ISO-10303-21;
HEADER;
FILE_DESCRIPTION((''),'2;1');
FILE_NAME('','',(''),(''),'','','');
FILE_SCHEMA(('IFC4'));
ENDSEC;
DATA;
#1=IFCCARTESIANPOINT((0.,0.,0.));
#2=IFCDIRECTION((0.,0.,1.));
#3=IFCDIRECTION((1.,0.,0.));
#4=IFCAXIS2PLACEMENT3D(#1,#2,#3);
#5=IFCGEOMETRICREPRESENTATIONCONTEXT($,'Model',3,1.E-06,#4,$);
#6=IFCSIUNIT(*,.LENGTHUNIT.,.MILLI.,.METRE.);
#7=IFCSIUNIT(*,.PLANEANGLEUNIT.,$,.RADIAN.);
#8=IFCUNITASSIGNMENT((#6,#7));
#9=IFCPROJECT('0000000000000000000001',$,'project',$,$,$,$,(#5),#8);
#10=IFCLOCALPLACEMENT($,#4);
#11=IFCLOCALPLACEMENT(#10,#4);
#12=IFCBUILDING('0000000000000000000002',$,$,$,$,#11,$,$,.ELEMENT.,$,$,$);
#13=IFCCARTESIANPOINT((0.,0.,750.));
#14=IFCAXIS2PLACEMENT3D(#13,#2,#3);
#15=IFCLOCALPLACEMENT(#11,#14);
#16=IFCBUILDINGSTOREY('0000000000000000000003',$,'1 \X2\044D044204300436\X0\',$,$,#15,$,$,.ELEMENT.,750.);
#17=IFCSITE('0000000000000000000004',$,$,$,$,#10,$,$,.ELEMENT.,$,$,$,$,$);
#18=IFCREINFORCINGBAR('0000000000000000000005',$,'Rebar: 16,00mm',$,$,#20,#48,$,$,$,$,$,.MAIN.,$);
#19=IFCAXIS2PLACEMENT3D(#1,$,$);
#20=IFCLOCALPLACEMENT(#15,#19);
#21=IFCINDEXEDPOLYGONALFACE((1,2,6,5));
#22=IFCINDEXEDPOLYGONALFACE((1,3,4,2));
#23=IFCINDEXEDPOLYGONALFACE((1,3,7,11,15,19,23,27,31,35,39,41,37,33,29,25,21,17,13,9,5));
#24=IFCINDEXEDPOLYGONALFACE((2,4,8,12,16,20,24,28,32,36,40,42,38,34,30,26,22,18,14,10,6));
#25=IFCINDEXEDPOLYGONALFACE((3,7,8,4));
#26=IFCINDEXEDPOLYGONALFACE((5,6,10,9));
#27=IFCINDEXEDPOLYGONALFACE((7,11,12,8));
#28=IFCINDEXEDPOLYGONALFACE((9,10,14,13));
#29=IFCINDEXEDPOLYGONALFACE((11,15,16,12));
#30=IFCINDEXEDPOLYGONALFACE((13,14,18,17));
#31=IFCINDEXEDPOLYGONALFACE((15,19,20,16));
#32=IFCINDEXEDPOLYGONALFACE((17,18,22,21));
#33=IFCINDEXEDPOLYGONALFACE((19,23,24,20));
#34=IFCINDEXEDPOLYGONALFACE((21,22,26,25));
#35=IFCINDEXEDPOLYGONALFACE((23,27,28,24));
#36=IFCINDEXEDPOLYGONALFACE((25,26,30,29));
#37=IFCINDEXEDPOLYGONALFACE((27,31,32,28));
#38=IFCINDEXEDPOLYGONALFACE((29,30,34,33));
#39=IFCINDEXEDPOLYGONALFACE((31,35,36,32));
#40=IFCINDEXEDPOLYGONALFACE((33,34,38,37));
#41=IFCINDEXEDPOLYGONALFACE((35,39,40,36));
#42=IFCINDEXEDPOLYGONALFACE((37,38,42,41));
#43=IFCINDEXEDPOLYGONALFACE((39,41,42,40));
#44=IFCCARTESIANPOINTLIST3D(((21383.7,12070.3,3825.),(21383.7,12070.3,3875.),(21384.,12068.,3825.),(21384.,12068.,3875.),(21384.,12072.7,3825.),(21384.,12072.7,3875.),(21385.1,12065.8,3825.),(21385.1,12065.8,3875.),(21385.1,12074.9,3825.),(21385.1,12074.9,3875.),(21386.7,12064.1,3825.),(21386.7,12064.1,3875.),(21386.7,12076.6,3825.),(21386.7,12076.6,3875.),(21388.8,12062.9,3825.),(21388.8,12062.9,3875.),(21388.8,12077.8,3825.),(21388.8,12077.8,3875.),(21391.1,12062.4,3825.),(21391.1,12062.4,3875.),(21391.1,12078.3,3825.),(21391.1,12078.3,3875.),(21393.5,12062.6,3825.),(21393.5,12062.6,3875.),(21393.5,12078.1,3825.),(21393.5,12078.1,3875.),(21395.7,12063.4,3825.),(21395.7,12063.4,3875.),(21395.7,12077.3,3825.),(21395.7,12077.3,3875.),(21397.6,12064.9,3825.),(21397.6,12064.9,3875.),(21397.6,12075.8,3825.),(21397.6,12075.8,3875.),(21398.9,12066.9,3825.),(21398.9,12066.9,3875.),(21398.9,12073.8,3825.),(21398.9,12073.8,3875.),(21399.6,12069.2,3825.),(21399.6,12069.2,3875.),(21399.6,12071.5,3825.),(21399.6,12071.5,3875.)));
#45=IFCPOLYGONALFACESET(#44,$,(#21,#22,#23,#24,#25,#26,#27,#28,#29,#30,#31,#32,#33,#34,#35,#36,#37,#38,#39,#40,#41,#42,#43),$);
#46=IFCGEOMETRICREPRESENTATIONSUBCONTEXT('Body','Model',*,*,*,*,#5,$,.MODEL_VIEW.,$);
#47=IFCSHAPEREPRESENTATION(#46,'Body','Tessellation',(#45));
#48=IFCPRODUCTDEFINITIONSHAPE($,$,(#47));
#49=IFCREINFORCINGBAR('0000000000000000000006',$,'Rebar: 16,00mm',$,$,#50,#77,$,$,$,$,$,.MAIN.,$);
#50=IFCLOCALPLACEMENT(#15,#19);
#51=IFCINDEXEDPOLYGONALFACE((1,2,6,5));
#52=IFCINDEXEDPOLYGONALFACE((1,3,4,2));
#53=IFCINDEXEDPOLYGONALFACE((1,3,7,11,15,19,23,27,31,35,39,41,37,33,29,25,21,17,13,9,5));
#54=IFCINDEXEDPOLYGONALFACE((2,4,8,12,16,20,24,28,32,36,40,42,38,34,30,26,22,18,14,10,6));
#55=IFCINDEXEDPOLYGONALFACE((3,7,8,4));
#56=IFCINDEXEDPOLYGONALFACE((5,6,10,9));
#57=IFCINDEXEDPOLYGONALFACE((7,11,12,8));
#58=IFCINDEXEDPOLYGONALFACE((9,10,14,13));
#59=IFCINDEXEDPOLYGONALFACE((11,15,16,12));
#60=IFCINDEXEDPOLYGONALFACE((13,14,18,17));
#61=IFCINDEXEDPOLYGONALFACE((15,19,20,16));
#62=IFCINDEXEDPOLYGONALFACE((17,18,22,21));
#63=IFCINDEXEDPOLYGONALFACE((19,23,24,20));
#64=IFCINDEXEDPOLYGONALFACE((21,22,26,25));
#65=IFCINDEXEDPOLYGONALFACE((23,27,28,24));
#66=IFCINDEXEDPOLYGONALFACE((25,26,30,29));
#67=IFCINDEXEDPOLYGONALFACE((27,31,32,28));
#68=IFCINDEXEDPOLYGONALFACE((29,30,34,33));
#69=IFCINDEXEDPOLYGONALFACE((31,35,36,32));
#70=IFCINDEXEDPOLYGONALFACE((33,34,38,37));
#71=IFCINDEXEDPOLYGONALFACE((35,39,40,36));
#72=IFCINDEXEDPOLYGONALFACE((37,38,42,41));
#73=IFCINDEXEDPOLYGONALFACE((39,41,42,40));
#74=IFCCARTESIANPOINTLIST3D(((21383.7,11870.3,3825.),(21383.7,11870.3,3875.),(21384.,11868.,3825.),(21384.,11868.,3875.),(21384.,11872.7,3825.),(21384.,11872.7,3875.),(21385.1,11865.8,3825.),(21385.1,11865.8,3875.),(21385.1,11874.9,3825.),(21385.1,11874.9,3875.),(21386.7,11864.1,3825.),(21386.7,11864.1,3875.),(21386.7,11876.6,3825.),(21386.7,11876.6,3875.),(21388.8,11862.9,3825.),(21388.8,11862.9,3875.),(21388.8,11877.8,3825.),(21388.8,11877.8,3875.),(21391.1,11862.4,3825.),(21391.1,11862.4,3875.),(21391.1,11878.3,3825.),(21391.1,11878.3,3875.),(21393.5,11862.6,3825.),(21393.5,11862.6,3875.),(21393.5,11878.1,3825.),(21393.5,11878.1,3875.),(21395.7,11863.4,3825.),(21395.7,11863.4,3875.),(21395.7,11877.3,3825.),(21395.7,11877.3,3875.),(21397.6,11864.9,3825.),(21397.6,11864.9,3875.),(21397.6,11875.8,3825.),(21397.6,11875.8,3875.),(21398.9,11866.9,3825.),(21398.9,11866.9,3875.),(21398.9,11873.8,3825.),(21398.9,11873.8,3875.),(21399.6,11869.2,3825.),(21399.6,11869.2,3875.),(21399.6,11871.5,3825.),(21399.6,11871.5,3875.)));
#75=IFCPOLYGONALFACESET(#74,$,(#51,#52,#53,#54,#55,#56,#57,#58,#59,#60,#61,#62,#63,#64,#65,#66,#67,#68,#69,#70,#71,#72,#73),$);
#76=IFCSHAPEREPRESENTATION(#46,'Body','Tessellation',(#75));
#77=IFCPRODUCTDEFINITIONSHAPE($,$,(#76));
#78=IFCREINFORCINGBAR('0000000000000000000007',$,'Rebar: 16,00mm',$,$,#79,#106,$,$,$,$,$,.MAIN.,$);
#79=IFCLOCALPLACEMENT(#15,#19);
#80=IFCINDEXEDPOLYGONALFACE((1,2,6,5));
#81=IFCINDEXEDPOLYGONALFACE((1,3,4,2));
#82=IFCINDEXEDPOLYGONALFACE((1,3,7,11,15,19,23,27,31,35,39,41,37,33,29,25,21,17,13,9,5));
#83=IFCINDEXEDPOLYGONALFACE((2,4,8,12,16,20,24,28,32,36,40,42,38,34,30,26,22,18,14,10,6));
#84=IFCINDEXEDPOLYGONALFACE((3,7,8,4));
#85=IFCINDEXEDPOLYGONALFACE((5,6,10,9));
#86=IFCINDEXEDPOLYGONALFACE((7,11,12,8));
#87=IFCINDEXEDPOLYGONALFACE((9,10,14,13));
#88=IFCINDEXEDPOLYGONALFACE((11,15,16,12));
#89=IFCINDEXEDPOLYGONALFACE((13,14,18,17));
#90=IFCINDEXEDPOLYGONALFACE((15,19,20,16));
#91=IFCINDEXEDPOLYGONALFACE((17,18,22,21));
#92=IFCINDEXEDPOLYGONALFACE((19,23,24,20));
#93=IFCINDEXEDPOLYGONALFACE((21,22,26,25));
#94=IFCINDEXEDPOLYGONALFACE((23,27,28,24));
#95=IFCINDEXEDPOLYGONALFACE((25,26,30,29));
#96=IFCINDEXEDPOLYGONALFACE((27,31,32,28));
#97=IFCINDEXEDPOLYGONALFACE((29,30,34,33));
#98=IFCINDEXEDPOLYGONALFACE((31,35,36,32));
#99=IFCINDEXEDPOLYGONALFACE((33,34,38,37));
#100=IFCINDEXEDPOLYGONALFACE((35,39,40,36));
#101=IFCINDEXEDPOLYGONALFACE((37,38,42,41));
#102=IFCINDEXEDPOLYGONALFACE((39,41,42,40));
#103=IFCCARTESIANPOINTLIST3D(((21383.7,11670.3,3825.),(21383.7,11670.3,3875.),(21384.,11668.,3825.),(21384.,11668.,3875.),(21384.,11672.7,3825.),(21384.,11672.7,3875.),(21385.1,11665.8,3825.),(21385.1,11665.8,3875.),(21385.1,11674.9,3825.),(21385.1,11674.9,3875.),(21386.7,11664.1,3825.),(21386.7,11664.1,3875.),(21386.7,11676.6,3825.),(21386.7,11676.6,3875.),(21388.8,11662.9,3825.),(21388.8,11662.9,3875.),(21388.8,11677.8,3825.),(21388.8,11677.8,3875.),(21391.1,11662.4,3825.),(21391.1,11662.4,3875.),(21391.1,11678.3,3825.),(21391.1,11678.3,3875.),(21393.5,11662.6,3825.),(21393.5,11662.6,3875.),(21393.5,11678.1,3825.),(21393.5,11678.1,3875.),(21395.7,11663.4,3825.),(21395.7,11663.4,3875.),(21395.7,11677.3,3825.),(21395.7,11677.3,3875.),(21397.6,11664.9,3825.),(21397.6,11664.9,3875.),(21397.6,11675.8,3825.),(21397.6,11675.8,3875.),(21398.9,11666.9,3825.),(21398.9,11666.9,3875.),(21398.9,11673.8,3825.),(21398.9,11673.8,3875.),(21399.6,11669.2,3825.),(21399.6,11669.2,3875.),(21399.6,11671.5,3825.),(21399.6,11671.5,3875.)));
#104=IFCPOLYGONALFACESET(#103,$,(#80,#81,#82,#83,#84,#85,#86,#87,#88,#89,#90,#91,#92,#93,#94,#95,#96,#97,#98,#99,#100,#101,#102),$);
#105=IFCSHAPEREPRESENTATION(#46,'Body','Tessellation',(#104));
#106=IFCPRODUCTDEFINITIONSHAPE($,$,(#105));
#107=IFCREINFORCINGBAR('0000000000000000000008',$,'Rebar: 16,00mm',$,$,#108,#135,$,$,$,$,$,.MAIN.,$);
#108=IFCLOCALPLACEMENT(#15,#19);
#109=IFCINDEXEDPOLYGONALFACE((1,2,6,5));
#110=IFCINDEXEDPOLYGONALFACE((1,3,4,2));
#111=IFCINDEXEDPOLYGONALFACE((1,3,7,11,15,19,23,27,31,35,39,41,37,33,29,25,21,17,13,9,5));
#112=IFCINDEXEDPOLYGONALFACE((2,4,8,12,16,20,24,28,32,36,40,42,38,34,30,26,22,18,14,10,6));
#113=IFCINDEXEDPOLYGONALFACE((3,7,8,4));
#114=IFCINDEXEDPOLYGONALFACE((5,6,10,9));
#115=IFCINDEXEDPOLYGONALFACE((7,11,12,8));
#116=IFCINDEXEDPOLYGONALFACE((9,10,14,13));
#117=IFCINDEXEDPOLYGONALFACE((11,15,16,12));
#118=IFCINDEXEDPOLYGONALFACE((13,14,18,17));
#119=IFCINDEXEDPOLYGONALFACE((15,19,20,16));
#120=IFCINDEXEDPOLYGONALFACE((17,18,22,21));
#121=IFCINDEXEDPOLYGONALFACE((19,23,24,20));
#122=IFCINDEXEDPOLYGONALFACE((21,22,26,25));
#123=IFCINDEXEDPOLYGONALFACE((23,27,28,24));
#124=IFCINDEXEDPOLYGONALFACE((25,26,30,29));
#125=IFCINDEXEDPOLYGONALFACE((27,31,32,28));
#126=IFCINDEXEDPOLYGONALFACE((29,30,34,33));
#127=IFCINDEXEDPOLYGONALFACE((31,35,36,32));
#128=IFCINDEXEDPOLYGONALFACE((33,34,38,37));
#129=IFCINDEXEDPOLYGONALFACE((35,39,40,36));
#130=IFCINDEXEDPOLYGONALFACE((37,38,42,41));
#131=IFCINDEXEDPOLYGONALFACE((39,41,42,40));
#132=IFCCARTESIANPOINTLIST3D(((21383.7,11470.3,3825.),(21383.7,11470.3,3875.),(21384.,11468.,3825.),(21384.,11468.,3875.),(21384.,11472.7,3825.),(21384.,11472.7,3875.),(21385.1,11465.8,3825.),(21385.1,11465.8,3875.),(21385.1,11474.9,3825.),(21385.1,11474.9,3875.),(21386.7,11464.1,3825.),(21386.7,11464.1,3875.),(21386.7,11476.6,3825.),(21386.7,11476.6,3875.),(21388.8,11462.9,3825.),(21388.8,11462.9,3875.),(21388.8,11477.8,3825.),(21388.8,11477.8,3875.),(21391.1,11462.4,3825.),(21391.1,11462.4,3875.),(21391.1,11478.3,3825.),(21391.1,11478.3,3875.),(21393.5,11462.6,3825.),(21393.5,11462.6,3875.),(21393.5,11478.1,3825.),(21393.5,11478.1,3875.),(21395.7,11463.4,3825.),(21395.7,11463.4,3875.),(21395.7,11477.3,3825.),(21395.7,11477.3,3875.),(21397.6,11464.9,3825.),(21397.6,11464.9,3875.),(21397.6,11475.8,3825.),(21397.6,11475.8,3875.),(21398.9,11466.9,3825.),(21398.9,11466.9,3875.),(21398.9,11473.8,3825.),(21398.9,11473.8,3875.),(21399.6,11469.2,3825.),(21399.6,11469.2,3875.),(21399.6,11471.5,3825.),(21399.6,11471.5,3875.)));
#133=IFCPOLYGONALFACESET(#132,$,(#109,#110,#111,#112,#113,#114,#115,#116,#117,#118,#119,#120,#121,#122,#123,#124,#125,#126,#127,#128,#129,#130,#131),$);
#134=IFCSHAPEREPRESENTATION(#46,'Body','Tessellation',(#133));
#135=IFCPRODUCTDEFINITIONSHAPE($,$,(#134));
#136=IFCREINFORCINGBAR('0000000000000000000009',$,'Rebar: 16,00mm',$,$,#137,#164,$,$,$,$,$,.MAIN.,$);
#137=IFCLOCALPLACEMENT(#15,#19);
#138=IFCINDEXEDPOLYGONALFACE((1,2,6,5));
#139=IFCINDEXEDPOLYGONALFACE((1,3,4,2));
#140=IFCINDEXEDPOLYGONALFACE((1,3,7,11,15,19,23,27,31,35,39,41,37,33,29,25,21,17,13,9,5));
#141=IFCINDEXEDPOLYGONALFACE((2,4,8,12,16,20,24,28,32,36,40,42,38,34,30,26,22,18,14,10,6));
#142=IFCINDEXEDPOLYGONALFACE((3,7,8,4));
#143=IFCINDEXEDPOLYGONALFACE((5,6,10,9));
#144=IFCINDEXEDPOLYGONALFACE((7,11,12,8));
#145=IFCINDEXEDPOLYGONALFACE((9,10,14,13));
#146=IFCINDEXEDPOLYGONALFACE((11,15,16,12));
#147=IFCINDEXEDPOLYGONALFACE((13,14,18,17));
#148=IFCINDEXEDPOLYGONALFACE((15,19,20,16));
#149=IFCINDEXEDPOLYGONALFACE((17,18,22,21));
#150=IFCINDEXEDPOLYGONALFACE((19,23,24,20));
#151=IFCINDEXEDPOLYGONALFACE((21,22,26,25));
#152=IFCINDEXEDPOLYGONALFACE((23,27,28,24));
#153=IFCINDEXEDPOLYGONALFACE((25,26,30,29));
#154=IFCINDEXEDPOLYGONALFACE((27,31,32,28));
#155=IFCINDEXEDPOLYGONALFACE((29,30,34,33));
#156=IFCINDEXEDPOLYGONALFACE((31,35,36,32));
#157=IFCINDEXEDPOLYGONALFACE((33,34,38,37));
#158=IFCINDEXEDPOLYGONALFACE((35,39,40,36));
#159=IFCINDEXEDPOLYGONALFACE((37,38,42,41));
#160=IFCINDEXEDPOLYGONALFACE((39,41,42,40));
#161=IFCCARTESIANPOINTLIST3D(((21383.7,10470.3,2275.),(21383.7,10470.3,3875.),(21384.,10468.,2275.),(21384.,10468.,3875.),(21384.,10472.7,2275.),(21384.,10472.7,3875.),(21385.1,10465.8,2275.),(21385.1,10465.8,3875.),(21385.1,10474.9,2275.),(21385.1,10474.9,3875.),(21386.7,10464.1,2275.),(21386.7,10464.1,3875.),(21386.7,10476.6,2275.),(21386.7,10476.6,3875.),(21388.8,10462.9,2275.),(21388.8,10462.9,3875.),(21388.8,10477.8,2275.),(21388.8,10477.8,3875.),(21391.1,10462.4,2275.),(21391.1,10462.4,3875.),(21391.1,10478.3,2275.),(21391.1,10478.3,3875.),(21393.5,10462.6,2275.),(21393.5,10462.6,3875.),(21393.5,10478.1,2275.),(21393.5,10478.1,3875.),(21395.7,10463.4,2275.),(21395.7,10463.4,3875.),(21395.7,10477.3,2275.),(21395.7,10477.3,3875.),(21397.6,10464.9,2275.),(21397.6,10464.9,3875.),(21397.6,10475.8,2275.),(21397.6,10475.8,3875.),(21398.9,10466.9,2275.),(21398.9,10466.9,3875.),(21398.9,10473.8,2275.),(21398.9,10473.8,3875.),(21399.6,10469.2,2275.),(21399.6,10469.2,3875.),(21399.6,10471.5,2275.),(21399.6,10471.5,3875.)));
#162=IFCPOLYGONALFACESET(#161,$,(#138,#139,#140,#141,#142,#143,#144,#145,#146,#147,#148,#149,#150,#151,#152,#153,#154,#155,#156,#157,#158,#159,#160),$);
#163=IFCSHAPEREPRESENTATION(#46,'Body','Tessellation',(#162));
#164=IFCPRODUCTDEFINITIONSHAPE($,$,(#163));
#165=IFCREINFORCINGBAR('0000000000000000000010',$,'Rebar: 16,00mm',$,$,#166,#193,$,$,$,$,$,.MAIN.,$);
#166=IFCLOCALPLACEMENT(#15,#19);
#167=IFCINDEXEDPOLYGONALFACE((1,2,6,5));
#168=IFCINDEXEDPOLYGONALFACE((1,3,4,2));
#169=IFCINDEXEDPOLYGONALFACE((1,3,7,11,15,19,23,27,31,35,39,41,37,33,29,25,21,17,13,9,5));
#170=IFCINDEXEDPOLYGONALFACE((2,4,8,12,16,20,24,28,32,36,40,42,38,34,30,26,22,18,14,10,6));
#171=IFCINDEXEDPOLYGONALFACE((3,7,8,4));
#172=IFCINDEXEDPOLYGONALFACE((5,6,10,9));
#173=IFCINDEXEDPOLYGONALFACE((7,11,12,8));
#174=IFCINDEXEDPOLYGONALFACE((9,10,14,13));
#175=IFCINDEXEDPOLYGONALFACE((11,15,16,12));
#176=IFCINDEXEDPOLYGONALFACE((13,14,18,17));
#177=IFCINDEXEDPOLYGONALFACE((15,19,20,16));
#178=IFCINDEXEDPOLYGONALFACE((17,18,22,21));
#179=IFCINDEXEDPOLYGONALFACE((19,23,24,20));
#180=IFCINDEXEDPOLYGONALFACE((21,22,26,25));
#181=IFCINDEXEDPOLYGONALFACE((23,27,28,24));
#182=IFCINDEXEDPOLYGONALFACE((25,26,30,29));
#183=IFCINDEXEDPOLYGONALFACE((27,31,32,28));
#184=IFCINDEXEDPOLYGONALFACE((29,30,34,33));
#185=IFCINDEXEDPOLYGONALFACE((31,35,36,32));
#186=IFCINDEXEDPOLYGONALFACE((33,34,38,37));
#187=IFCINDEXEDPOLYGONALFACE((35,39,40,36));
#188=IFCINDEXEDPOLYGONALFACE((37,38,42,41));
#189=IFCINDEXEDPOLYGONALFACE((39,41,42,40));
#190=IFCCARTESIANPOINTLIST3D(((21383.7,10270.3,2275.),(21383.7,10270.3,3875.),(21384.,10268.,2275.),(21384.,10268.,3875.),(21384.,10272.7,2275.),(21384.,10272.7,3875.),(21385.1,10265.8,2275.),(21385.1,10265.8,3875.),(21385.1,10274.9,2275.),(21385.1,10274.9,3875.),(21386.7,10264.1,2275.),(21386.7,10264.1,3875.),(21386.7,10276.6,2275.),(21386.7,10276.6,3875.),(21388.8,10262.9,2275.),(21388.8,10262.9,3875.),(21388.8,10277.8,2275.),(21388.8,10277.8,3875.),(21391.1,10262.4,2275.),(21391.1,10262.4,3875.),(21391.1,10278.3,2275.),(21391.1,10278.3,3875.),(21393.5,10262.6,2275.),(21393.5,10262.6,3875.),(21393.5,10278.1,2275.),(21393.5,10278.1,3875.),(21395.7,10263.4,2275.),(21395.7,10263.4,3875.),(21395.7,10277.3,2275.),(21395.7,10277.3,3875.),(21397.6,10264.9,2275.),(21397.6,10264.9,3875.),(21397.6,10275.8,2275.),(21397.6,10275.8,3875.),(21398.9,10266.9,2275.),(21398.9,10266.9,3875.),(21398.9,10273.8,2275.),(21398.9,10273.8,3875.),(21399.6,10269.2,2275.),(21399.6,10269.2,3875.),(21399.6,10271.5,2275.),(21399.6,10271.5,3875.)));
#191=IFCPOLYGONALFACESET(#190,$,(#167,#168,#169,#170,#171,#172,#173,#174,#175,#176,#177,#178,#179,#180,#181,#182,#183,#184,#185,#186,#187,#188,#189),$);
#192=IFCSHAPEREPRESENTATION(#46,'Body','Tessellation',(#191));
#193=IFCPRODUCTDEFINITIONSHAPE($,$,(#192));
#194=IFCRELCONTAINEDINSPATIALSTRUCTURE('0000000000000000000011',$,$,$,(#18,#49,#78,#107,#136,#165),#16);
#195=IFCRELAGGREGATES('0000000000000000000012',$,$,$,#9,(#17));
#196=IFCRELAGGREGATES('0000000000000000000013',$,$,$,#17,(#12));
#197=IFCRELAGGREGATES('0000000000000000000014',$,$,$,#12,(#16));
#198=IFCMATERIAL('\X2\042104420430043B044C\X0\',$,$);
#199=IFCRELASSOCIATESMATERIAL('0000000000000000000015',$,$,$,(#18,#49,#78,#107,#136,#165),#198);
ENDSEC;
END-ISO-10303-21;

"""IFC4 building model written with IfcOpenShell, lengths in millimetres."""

from ifc_helpers import new_model, entity, si_unit, frame, origin_with_axes, place, context, subcontext, project, spatial, source, transform, mapped, material, element, save


model = new_model("IFC4")

# Units and contexts
model_context = context("Model", 3, precision=1e-06, world=origin_with_axes())
body_context = subcontext(model_context, "Body", "Model", "MODEL_VIEW")
ifc_project = project(units=[si_unit("LENGTHUNIT", "METRE", prefix="MILLI"), si_unit("PLANEANGLEUNIT", "RADIAN")], contexts=[model_context])

# Site, building, storey
site_placement = place(None, origin_with_axes())
site = spatial("IfcSite", under=ifc_project, at=site_placement, CompositionType="ELEMENT")
building_placement = place(site_placement, origin_with_axes())
building = spatial("IfcBuilding", under=site, at=building_placement, CompositionType="ELEMENT")
storey_placement = place(building_placement, frame((0.0, 0.0, 750.0), z_axis=(0.0, 0.0, 1.0), x_axis=(1.0, 0.0, 0.0)))
storey = spatial("IfcBuildingStorey", under=building, at=storey_placement, Name="1 этаж", CompositionType="ELEMENT", Elevation=750.0)

# Reinforcing bars
ifc_material = material(Name="Сталь")
shared_shape_1 = source(origin_with_axes(), body_context, "Body", "AdvancedSweptSolid", [
    entity("IfcSweptDiskSolid", entity("IfcIndexedPolyCurve", entity("IfcCartesianPointList3D", [[0.0, 0.0, 0.0], [50.0, 0.0, 0.0]]), [entity("IfcLineIndex", [1, 2])]), 8.0),
])
reinforcing_bar_1_placement = place(storey_placement, origin_with_axes())
element("IfcReinforcingBar", 1, at=reinforcing_bar_1_placement, inside=storey, material=ifc_material, Name="Rebar: 16,00mm", PredefinedType="MAIN", context=body_context, shape_type="MappedRepresentation", body=[
    mapped(shared_shape_1, transform((21391.7, 12070.3, 3825.0), x_axis=(0.0, 0.0, 1.0), y_axis=(0.0, 1.0, 0.0), z_axis=(-1.0, 0.0, 0.0), scale=1.0)),
])
reinforcing_bar_2_placement = place(storey_placement, origin_with_axes())
element("IfcReinforcingBar", 2, at=reinforcing_bar_2_placement, inside=storey, material=ifc_material, Name="Rebar: 16,00mm", PredefinedType="MAIN", context=body_context, shape_type="MappedRepresentation", body=[
    mapped(shared_shape_1, transform((21391.7, 11870.3, 3825.0), x_axis=(0.0, 0.0, 1.0), y_axis=(0.0, 1.0, 0.0), z_axis=(-1.0, 0.0, 0.0), scale=1.0)),
])
reinforcing_bar_3_placement = place(storey_placement, origin_with_axes())
element("IfcReinforcingBar", 3, at=reinforcing_bar_3_placement, inside=storey, material=ifc_material, Name="Rebar: 16,00mm", PredefinedType="MAIN", context=body_context, shape_type="MappedRepresentation", body=[
    mapped(shared_shape_1, transform((21391.7, 11670.3, 3825.0), x_axis=(0.0, 0.0, 1.0), y_axis=(0.0, 1.0, 0.0), z_axis=(-1.0, 0.0, 0.0), scale=1.0)),
])
reinforcing_bar_4_placement = place(storey_placement, origin_with_axes())
element("IfcReinforcingBar", 4, at=reinforcing_bar_4_placement, inside=storey, material=ifc_material, Name="Rebar: 16,00mm", PredefinedType="MAIN", context=body_context, shape_type="MappedRepresentation", body=[
    mapped(shared_shape_1, transform((21391.7, 11470.3, 3825.0), x_axis=(0.0, 0.0, 1.0), y_axis=(0.0, 1.0, 0.0), z_axis=(-1.0, 0.0, 0.0), scale=1.0)),
])
shared_shape_2 = source(origin_with_axes(), body_context, "Body", "AdvancedSweptSolid", [
    entity("IfcSweptDiskSolid", entity("IfcIndexedPolyCurve", entity("IfcCartesianPointList3D", [[0.0, 0.0, 0.0], [1600.0, 0.0, 0.0]]), [entity("IfcLineIndex", [1, 2])]), 8.0),
])
reinforcing_bar_5_placement = place(storey_placement, origin_with_axes())
element("IfcReinforcingBar", 5, at=reinforcing_bar_5_placement, inside=storey, material=ifc_material, Name="Rebar: 16,00mm", PredefinedType="MAIN", context=body_context, shape_type="MappedRepresentation", body=[
    mapped(shared_shape_2, transform((21391.7, 10470.3, 2275.0), x_axis=(0.0, 0.0, 1.0), y_axis=(0.0, 1.0, 0.0), z_axis=(-1.0, 0.0, 0.0), scale=1.0)),
])
reinforcing_bar_6_placement = place(storey_placement, origin_with_axes())
element("IfcReinforcingBar", 6, at=reinforcing_bar_6_placement, inside=storey, material=ifc_material, Name="Rebar: 16,00mm", PredefinedType="MAIN", context=body_context, shape_type="MappedRepresentation", body=[
    mapped(shared_shape_2, transform((21391.7, 10270.3, 2275.0), x_axis=(0.0, 0.0, 1.0), y_axis=(0.0, 1.0, 0.0), z_axis=(-1.0, 0.0, 0.0), scale=1.0)),
])

save(model, "model.ifc")
